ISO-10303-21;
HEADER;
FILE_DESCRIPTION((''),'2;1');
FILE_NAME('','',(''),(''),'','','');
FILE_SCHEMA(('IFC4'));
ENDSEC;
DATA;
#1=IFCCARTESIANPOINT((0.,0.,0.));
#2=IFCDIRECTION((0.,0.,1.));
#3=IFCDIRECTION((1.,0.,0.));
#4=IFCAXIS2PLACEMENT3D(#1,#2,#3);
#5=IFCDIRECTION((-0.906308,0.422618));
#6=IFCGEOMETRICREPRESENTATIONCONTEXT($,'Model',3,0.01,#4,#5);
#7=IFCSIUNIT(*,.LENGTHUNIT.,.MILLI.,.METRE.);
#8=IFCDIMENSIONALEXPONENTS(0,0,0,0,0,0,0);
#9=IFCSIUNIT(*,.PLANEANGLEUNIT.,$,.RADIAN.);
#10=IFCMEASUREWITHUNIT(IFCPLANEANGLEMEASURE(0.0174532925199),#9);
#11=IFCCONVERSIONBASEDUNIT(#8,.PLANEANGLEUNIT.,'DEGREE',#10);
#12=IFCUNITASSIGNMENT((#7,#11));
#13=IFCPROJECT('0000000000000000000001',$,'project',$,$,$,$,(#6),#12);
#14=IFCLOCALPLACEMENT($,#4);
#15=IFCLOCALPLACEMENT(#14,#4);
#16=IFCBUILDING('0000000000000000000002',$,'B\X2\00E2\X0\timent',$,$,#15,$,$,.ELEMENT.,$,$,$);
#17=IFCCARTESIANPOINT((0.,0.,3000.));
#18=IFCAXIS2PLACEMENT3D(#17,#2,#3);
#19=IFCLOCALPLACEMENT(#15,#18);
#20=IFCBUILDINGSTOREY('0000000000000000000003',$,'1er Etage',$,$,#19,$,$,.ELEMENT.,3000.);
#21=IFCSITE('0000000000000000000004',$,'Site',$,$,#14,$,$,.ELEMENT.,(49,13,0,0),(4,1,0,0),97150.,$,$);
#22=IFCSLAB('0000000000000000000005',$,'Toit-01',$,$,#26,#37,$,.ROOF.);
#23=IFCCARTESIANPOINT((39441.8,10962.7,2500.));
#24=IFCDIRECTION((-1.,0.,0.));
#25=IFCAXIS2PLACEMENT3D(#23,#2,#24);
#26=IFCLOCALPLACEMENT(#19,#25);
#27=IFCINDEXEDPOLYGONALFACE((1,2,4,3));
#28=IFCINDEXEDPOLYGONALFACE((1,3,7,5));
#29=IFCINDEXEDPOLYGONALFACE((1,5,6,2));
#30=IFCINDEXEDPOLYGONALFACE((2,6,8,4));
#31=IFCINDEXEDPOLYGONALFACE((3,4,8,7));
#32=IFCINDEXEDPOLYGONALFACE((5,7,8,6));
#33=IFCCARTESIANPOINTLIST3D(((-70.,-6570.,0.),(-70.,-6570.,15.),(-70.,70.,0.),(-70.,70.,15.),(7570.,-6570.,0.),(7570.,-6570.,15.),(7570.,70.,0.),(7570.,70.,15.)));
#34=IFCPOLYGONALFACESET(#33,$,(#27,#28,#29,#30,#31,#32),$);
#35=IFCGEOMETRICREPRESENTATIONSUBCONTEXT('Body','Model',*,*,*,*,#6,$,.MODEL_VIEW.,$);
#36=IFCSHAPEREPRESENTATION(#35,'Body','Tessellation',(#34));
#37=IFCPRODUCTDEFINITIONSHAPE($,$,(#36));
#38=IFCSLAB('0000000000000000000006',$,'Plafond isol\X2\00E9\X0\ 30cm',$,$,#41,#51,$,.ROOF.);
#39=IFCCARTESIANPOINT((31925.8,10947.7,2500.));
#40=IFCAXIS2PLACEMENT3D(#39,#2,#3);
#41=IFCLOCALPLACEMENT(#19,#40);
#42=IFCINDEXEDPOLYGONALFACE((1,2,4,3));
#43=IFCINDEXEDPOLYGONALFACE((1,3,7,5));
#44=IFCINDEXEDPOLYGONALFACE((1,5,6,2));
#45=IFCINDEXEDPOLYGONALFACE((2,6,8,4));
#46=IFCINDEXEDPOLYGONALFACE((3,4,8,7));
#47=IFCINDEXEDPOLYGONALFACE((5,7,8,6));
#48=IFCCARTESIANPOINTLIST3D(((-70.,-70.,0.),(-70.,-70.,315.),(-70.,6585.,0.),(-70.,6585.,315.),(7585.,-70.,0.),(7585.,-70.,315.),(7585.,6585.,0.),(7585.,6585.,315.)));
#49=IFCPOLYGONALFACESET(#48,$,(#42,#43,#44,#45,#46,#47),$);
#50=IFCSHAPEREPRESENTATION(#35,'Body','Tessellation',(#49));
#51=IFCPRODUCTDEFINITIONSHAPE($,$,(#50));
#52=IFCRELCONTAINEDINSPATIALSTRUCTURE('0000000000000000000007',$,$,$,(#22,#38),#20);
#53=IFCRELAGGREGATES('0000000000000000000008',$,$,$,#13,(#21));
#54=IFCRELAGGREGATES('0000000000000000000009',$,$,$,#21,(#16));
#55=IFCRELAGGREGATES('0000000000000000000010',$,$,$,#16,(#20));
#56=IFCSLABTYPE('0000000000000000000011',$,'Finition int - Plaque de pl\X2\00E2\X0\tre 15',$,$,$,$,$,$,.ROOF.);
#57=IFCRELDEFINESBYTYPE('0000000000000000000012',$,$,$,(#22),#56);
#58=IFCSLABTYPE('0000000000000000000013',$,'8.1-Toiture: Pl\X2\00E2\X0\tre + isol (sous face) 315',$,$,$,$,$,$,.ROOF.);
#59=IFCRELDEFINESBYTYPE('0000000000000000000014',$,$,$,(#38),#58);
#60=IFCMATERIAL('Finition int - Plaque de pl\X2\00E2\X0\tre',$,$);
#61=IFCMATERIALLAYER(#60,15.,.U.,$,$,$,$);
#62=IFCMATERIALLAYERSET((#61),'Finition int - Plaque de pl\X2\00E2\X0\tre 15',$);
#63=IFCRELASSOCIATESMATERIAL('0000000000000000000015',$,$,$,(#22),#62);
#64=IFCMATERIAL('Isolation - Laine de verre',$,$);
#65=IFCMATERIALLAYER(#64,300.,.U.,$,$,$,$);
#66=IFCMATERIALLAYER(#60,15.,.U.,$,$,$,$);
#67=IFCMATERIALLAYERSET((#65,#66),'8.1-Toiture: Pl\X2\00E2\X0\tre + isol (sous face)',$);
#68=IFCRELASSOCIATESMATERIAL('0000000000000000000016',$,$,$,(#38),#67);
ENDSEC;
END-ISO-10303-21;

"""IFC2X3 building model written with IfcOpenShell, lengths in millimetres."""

from ifc_helpers import new_model, entity, si_unit, converted_unit, direction, frame, origin_with_axes, place, context, subcontext, project, spatial, polyline, outline, extrude, material, layer, layer_set, layer_usage, type_object, element, save


model = new_model("IFC2X3")

# Units and contexts
model_context = context("Model", 3, precision=0.01, world=origin_with_axes(), true_north=direction((-0.906308, 0.422618)))
body_context = subcontext(model_context, "Body", "Model", "MODEL_VIEW")
ifc_project = project(units=[si_unit("LENGTHUNIT", "METRE", prefix="MILLI"), converted_unit("PLANEANGLEUNIT", "DEGREE", entity("IfcPlaneAngleMeasure", 0.0174532925199), si_unit("PLANEANGLEUNIT", "RADIAN"), dimensions=[0, 0, 0, 0, 0, 0, 0])], contexts=[model_context])

# Site, building, storey
site_placement = place(None, origin_with_axes())
site = spatial("IfcSite", under=ifc_project, at=site_placement, Name="Site", CompositionType="ELEMENT", RefLatitude=(49, 13, 0, 0), RefLongitude=(4, 1, 0, 0), RefElevation=97150.0)
building_placement = place(site_placement, origin_with_axes())
building = spatial("IfcBuilding", under=site, at=building_placement, Name="Bâtiment", CompositionType="ELEMENT")
storey_placement = place(building_placement, frame((0.0, 0.0, 3000.0), z_axis=(0.0, 0.0, 1.0), x_axis=(1.0, 0.0, 0.0)))
storey = spatial("IfcBuildingStorey", under=building, at=storey_placement, Name="1er Etage", CompositionType="ELEMENT", Elevation=3000.0)

# Slabs
ifc_material_1 = material(Name="Finition int - Plaque de plâtre")
ifc_layer_1 = layer(ifc_material_1, 15.0, ventilated="UNKNOWN")
ifc_layer_set_1 = layer_set([ifc_layer_1], Name="Finition int - Plaque de plâtre 15")
ifc_layer_usage_1 = layer_usage(ifc_layer_set_1, "AXIS3", "NEGATIVE", 15.0)
slab_type_1 = type_object("IfcSlabType", Name="Finition int - Plaque de plâtre 15", PredefinedType="ROOF")
slab_1_placement = place(storey_placement, frame((39441.8, 10962.7, 2500.0), z_axis=(0.0, 0.0, 1.0), x_axis=(-1.0, 0.0, 0.0)))
element("IfcSlab", 1, at=slab_1_placement, inside=storey, type_object=slab_type_1, material=ifc_layer_usage_1, Name="Toit-01", PredefinedType="ROOF", context=body_context, shape_type="SweptSolid", body=[
    extrude(outline(polyline([(7570.0, -6570.0), (7570.0, 70.0), (-70.0, 70.0), (-70.0, -6570.0), (7570.0, -6570.0)])), origin_with_axes(), (0.0, 0.0, 1.0), 15.0),
])
ifc_material_2 = material(Name="Isolation - Laine de verre")
ifc_layer_2 = layer(ifc_material_2, 300.0, ventilated="UNKNOWN")
ifc_layer_3 = layer(ifc_material_1, 15.0, ventilated="UNKNOWN")
ifc_layer_set_2 = layer_set([ifc_layer_2, ifc_layer_3], Name="8.1-Toiture: Plâtre + isol (sous face)")
ifc_layer_usage_2 = layer_usage(ifc_layer_set_2, "AXIS3", "NEGATIVE", 315.0)
slab_type_2 = type_object("IfcSlabType", Name="8.1-Toiture: Plâtre + isol (sous face) 315", PredefinedType="ROOF")
slab_2_placement = place(storey_placement, frame((31925.8, 10947.7, 2500.0), z_axis=(0.0, 0.0, 1.0), x_axis=(1.0, 0.0, 0.0)))
element("IfcSlab", 2, at=slab_2_placement, inside=storey, type_object=slab_type_2, material=ifc_layer_usage_2, Name="Plafond isolé 30cm", PredefinedType="ROOF", context=body_context, shape_type="SweptSolid", body=[
    extrude(outline(polyline([(7585.0, -70.0), (7585.0, 6585.0), (-70.0, 6585.0), (-70.0, -70.0), (7585.0, -70.0)])), origin_with_axes(), (0.0, 0.0, 1.0), 315.0),
])

save(model, "model.ifc")
